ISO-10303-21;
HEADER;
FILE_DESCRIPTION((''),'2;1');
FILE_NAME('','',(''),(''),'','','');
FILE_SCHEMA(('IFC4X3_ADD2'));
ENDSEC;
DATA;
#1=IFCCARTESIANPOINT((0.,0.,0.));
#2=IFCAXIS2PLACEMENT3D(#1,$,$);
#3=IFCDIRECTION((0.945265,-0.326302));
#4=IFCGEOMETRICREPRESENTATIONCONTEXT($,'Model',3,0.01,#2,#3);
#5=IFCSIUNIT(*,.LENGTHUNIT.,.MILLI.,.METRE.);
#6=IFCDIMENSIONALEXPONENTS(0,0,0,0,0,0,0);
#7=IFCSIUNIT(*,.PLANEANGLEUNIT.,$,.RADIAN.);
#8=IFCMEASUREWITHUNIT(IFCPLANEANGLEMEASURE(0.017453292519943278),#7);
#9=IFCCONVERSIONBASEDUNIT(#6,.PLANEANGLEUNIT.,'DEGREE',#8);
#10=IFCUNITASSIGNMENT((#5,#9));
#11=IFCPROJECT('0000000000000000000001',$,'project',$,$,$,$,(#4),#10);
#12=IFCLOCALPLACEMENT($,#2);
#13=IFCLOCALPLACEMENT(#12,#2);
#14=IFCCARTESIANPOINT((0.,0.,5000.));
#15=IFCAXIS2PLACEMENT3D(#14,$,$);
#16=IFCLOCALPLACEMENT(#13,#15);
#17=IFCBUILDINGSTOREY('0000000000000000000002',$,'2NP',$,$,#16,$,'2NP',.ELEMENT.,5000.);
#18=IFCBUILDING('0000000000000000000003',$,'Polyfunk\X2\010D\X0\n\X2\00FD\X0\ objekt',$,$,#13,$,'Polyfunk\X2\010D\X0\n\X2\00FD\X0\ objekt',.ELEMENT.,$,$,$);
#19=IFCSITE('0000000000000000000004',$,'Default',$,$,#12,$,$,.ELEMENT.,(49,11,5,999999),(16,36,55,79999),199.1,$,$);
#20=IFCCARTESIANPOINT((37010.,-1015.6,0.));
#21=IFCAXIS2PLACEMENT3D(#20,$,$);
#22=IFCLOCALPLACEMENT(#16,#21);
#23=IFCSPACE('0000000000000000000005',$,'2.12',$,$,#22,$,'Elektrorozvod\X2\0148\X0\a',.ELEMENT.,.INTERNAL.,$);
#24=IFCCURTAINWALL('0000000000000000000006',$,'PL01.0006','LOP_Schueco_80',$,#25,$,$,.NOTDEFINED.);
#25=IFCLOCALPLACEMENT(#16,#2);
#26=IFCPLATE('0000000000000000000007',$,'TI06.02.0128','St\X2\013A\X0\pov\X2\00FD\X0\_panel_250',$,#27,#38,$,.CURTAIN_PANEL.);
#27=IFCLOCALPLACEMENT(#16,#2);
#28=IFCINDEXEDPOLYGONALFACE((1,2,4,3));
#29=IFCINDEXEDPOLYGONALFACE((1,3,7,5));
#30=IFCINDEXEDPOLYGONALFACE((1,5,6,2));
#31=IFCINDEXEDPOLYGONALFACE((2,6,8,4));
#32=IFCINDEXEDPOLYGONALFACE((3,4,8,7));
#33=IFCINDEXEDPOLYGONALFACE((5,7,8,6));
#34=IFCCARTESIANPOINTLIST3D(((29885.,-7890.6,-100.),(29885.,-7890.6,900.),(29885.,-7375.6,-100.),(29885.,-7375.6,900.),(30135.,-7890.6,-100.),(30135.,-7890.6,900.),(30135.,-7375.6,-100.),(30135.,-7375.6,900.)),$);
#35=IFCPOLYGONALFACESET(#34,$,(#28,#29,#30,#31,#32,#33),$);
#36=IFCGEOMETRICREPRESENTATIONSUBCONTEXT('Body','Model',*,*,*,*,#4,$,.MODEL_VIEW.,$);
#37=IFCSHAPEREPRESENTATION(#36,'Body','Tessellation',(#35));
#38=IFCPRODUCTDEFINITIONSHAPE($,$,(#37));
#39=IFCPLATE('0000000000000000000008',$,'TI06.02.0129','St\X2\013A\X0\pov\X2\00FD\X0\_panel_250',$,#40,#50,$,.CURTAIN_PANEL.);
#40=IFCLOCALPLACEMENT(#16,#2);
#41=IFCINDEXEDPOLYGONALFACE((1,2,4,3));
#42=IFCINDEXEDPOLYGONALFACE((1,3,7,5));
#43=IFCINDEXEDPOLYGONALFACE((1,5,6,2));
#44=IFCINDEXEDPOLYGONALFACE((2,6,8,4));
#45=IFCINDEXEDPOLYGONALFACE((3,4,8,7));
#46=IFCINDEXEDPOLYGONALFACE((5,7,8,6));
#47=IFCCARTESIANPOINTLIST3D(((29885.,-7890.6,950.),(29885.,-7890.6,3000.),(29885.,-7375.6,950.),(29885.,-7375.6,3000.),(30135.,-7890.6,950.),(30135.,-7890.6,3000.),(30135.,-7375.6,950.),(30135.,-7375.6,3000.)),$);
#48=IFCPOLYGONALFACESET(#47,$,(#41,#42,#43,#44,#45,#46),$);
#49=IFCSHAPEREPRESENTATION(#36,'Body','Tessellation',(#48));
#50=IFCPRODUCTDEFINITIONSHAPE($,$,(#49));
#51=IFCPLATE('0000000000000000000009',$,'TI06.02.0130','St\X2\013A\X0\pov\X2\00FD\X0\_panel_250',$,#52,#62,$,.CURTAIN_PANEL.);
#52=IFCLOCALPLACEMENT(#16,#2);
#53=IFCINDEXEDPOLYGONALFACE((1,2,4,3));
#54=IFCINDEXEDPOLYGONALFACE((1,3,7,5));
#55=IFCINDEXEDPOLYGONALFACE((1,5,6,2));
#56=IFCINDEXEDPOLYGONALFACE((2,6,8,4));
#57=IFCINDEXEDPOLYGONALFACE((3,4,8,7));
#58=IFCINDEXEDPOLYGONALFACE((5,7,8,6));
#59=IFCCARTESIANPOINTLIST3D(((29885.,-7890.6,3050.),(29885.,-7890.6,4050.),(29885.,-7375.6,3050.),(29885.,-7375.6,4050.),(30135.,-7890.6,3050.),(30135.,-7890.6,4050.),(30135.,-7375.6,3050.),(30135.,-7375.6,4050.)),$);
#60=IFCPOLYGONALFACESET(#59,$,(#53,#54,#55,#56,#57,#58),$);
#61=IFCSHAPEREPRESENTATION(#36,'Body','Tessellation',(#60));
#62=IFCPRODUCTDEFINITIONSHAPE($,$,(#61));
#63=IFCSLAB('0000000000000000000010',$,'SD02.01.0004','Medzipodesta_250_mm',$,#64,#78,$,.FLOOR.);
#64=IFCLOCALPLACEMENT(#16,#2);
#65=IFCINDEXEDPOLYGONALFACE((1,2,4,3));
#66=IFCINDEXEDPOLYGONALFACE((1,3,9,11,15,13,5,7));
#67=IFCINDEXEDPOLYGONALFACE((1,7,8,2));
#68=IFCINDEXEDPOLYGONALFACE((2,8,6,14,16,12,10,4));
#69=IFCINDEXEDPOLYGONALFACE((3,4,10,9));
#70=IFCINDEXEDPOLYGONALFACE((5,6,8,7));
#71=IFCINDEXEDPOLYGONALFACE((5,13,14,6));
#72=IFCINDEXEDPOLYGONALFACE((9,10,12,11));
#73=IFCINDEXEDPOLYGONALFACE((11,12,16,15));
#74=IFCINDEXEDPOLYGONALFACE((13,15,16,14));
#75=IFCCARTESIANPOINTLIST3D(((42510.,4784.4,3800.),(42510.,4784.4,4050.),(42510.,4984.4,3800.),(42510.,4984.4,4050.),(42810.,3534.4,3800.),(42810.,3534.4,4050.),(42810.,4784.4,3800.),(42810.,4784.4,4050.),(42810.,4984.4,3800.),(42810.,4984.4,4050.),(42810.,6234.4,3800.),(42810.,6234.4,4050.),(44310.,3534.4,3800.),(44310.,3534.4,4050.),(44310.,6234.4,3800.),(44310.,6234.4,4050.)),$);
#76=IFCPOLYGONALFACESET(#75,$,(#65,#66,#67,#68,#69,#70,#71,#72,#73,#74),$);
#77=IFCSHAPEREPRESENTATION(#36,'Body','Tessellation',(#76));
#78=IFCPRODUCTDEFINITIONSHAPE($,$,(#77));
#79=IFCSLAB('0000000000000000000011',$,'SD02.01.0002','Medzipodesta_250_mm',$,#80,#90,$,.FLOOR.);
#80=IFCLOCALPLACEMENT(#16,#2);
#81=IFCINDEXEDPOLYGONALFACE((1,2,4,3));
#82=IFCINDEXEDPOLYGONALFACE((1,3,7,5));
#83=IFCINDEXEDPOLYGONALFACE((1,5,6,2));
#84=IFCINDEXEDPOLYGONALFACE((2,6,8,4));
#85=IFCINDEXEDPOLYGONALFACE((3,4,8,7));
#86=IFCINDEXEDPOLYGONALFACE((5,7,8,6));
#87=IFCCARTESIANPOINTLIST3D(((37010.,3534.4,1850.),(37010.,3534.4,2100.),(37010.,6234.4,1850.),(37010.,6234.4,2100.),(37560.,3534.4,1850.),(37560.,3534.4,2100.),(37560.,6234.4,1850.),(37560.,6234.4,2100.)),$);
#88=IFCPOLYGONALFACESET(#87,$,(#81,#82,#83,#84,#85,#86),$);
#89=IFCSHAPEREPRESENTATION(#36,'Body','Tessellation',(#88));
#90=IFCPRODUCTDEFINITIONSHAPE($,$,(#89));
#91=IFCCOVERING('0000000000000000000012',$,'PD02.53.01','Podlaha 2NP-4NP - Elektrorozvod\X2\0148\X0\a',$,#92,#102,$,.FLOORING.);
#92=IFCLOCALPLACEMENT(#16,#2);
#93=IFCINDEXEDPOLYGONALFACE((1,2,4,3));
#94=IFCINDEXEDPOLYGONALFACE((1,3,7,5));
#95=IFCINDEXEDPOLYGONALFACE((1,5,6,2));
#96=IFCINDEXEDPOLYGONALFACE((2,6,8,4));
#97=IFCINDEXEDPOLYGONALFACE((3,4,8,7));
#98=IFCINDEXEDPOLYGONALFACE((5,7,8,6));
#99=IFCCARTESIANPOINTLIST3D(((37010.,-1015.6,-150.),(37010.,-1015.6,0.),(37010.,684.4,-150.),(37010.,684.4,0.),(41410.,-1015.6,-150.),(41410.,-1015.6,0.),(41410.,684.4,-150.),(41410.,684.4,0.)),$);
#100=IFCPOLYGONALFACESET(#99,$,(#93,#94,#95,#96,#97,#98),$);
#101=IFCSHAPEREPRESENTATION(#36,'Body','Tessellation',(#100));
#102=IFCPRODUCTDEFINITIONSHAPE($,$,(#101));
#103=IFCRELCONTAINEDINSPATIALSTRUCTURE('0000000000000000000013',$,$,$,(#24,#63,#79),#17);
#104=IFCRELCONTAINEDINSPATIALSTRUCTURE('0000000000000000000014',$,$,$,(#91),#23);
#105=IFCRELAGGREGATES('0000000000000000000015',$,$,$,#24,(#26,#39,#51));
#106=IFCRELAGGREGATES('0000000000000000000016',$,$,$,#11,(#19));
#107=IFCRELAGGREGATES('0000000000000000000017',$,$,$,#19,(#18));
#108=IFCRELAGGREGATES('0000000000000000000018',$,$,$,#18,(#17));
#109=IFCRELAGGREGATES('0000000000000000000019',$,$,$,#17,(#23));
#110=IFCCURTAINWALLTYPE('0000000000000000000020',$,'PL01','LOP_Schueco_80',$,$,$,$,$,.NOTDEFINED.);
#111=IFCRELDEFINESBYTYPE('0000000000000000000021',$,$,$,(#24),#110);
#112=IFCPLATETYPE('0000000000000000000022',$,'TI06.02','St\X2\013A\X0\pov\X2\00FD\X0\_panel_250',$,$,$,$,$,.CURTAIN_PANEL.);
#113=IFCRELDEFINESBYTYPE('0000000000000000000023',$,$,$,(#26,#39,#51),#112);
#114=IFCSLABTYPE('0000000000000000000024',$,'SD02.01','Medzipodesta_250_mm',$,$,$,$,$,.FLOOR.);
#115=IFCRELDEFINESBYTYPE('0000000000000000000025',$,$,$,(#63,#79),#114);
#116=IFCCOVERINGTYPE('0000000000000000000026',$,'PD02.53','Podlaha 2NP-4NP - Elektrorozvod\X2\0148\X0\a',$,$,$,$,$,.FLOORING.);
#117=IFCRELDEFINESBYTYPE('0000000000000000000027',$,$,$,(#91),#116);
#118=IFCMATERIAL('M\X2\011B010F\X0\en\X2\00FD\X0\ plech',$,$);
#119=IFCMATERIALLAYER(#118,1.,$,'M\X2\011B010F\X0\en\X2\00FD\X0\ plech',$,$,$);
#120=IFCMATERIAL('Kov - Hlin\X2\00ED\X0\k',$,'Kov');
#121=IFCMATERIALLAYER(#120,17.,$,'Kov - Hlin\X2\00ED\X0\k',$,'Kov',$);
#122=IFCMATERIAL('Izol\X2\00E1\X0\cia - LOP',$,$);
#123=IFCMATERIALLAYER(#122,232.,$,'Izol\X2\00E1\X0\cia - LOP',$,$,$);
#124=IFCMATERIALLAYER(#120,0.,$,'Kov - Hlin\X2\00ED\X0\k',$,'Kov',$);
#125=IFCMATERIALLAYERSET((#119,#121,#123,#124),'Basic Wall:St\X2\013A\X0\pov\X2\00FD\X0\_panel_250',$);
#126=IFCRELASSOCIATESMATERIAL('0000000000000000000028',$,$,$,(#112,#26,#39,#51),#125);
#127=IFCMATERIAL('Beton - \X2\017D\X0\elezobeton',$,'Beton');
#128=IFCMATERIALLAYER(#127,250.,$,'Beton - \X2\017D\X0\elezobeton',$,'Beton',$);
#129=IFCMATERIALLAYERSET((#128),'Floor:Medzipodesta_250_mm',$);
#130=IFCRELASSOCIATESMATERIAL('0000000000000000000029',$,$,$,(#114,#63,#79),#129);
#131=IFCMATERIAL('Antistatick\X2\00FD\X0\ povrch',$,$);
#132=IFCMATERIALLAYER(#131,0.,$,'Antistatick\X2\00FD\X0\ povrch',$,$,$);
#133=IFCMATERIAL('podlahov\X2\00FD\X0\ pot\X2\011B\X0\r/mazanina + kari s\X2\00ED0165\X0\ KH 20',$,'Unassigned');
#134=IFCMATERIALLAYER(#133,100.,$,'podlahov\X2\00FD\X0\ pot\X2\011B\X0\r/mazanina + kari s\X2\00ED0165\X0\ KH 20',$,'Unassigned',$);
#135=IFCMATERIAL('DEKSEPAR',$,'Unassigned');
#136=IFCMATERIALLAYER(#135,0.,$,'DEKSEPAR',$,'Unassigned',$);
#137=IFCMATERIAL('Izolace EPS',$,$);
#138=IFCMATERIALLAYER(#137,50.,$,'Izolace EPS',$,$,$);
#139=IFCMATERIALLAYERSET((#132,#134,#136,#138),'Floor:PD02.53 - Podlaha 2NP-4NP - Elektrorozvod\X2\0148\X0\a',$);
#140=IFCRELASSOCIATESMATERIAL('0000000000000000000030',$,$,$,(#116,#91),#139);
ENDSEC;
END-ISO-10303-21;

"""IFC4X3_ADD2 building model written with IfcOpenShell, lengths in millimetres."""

from ifc_helpers import new_model, entity, si_unit, converted_unit, direction, frame, frame_2d, origin, place, context, subcontext, project, spatial, polyline, rectangle, outline, extrude, material, layer, layer_set, layer_usage, type_object, element, aggregate, save


model = new_model("IFC4X3_ADD2")

# Units and contexts
model_context = context("Model", 3, precision=0.01, world=origin(), true_north=direction((0.945265, -0.326302)))
body_context = subcontext(model_context, "Body", "Model", "MODEL_VIEW")
ifc_project = project(units=[si_unit("LENGTHUNIT", "METRE", prefix="MILLI"), converted_unit("PLANEANGLEUNIT", "DEGREE", entity("IfcPlaneAngleMeasure", 0.017453292519943278), si_unit("PLANEANGLEUNIT", "RADIAN"), dimensions=[0, 0, 0, 0, 0, 0, 0])], contexts=[model_context])

# Site, building, storey
site_placement = place(None, origin())
site = spatial("IfcSite", under=ifc_project, at=site_placement, Name="Default", CompositionType="ELEMENT", RefLatitude=(49, 11, 5, 999999), RefLongitude=(16, 36, 55, 79999), RefElevation=199.1)
building_placement = place(site_placement, origin())
building = spatial("IfcBuilding", under=site, at=building_placement, Name="Polyfunkčný objekt", LongName="Polyfunkčný objekt", CompositionType="ELEMENT")
storey_placement = place(building_placement, frame((0.0, 0.0, 5000.0)))
storey = spatial("IfcBuildingStorey", under=building, at=storey_placement, Name="2NP", LongName="2NP", CompositionType="ELEMENT", Elevation=5000.0)

# Curtain wall
curtain_wall_type = type_object("IfcCurtainWallType", Name="PL01", Description="LOP_Schueco_80", PredefinedType="NOTDEFINED")
curtain_wall_1_placement = place(storey_placement, frame((0.0, 0.0, -5000.0)))
curtain_wall_1 = element("IfcCurtainWall", 1, at=curtain_wall_1_placement, inside=storey, type_object=curtain_wall_type, Name="PL01.0006", Description="LOP_Schueco_80", PredefinedType="NOTDEFINED")

# Shared definitions
ifc_material_1 = material(Name="Beton - Železobeton", Category="Beton")

# Shared definitions
ifc_material_2 = material(Name="Měďený plech")
ifc_layer_1 = layer(ifc_material_2, 1.0, Name="Měďený plech")
ifc_material_3 = material(Name="Kov - Hliník", Category="Kov")
ifc_layer_2 = layer(ifc_material_3, 17.0, Name="Kov - Hliník", Category="Kov")
ifc_material_4 = material(Name="Izolácia - LOP")
ifc_layer_3 = layer(ifc_material_4, 232.0, Name="Izolácia - LOP")
ifc_layer_4 = layer(ifc_material_3, 0.0, Name="Kov - Hliník", Category="Kov")
ifc_layer_set_1 = layer_set([ifc_layer_1, ifc_layer_2, ifc_layer_3, ifc_layer_4], Name="Basic Wall:Stĺpový_panel_250")
plate_type = type_object("IfcPlateType", Name="TI06.02", Description="Stĺpový_panel_250", PredefinedType="CURTAIN_PANEL", material=ifc_layer_set_1)

# Plates
ifc_layer_usage_1 = layer_usage(ifc_layer_set_1, "AXIS2", "POSITIVE", -125.0)
plate_1_placement = place(storey_placement, frame((30010.0, -7375.6, -100.0), z_axis=(0.0, 0.0, 1.0), x_axis=(0.0, -1.0, 0.0)))
plate_1 = element("IfcPlate", 2, at=plate_1_placement, type_object=plate_type, material=ifc_layer_usage_1, Name="TI06.02.0128", Description="Stĺpový_panel_250", PredefinedType="CURTAIN_PANEL", context=body_context, shape_type="SweptSolid", body=[
    extrude(rectangle(XDim=250.0, YDim=515.0, at=frame_2d((0.0, 0.0), x_axis=(1.0, 0.0))), frame((257.5, 0.0, 0.0), z_axis=(0.0, 0.0, 1.0), x_axis=(0.0, 1.0, 0.0)), (0.0, 0.0, 1.0), 1000.0),
])
ifc_layer_usage_2 = layer_usage(ifc_layer_set_1, "AXIS2", "POSITIVE", -125.0)
plate_2_placement = place(storey_placement, frame((30010.0, -7375.6, 950.0), z_axis=(0.0, 0.0, 1.0), x_axis=(0.0, -1.0, 0.0)))
plate_2 = element("IfcPlate", 3, at=plate_2_placement, type_object=plate_type, material=ifc_layer_usage_2, Name="TI06.02.0129", Description="Stĺpový_panel_250", PredefinedType="CURTAIN_PANEL", context=body_context, shape_type="SweptSolid", body=[
    extrude(rectangle(XDim=250.0, YDim=515.0, at=frame_2d((0.0, 0.0), x_axis=(1.0, 0.0))), frame((257.5, 0.0, 0.0), z_axis=(0.0, 0.0, 1.0), x_axis=(0.0, 1.0, 0.0)), (0.0, 0.0, 1.0), 2050.0),
])
ifc_layer_usage_3 = layer_usage(ifc_layer_set_1, "AXIS2", "POSITIVE", -125.0)
plate_3_placement = place(storey_placement, frame((30010.0, -7375.6, 3050.0), z_axis=(0.0, 0.0, 1.0), x_axis=(0.0, -1.0, 0.0)))
plate_3 = element("IfcPlate", 4, at=plate_3_placement, type_object=plate_type, material=ifc_layer_usage_3, Name="TI06.02.0130", Description="Stĺpový_panel_250", PredefinedType="CURTAIN_PANEL", context=body_context, shape_type="SweptSolid", body=[
    extrude(rectangle(XDim=250.0, YDim=515.0, at=frame_2d((0.0, 0.0), x_axis=(1.0, 0.0))), frame((257.5, 0.0, 0.0), z_axis=(0.0, 0.0, 1.0), x_axis=(0.0, 1.0, 0.0)), (0.0, 0.0, 1.0), 1000.0),
])
aggregate(curtain_wall_1, [plate_1, plate_2, plate_3])

# Slabs
ifc_layer_5 = layer(ifc_material_1, 250.0, Name="Beton - Železobeton", Category="Beton")
ifc_layer_set_2 = layer_set([ifc_layer_5], Name="Floor:Medzipodesta_250_mm")
ifc_layer_usage_4 = layer_usage(ifc_layer_set_2, "AXIS3", "POSITIVE", 0.0)
slab_type_1 = type_object("IfcSlabType", Name="SD02.01", Description="Medzipodesta_250_mm", PredefinedType="FLOOR", material=ifc_layer_set_2)
slab_1_placement = place(storey_placement, origin())
element("IfcSlab", 5, at=slab_1_placement, inside=storey, type_object=slab_type_1, material=ifc_layer_usage_4, Name="SD02.01.0004", Description="Medzipodesta_250_mm", PredefinedType="FLOOR", context=body_context, shape_type="SweptSolid", body=[
    extrude(outline(polyline([(-100.0, -600.0), (100.0, -600.0), (100.0, -300.0), (1350.0, -300.0), (1350.0, 1200.0), (-1350.0, 1200.0), (-1350.0, -300.0), (-100.0, -300.0), (-100.0, -600.0)])), frame((43110.0, 4884.4, 4050.0), z_axis=(0.0, 0.0, -1.0), x_axis=(0.0, 1.0, 0.0)), (0.0, 0.0, 1.0), 250.0),
])
ifc_layer_usage_5 = layer_usage(ifc_layer_set_2, "AXIS3", "POSITIVE", 0.0)
slab_2_placement = place(storey_placement, origin())
element("IfcSlab", 6, at=slab_2_placement, inside=storey, type_object=slab_type_1, material=ifc_layer_usage_5, Name="SD02.01.0002", Description="Medzipodesta_250_mm", PredefinedType="FLOOR", context=body_context, shape_type="SweptSolid", body=[
    extrude(rectangle(XDim=2700.0, YDim=550.0, at=frame_2d((0.0, 0.0), x_axis=(1.0, 0.0))), frame((37285.0, 4884.4, 2100.0), z_axis=(0.0, 0.0, -1.0), x_axis=(0.0, 1.0, 0.0)), (0.0, 0.0, 1.0), 250.0),
])

# Shared definitions
ifc_material_5 = material(Name="podlahový potěr/mazanina + kari síť KH 20", Category="Unassigned")
ifc_material_6 = material(Name="DEKSEPAR", Category="Unassigned")
ifc_material_7 = material(Name="Izolace EPS")

# Shared definitions
space_1_placement = place(storey_placement, frame((37010.0, -1015.6, 0.0)))
space_1 = spatial("IfcSpace", under=storey, at=space_1_placement, Name="2.12", LongName="Elektrorozvodňa", CompositionType="ELEMENT", PredefinedType="INTERNAL")

# Covering
ifc_material_8 = material(Name="Antistatický povrch")
ifc_layer_6 = layer(ifc_material_8, 0.0, Name="Antistatický povrch")
ifc_layer_7 = layer(ifc_material_5, 100.0, Name="podlahový potěr/mazanina + kari síť KH 20", Category="Unassigned")
ifc_layer_8 = layer(ifc_material_6, 0.0, Name="DEKSEPAR", Category="Unassigned")
ifc_layer_9 = layer(ifc_material_7, 50.0, Name="Izolace EPS")
ifc_layer_set_3 = layer_set([ifc_layer_6, ifc_layer_7, ifc_layer_8, ifc_layer_9], Name="Floor:PD02.53 - Podlaha 2NP-4NP - Elektrorozvodňa")
ifc_layer_usage_6 = layer_usage(ifc_layer_set_3, "AXIS3", "POSITIVE", 0.0)
covering_type_1 = type_object("IfcCoveringType", Name="PD02.53", Description="Podlaha 2NP-4NP - Elektrorozvodňa", PredefinedType="FLOORING", material=ifc_layer_set_3)
covering_1_placement = place(storey_placement, origin())
element("IfcCovering", 7, at=covering_1_placement, inside=space_1, type_object=covering_type_1, material=ifc_layer_usage_6, Name="PD02.53.01", Description="Podlaha 2NP-4NP - Elektrorozvodňa", PredefinedType="FLOORING", context=body_context, shape_type="SweptSolid", body=[
    extrude(rectangle(XDim=1700.0, YDim=4400.0, at=frame_2d((0.0, 0.0), x_axis=(1.0, 0.0))), frame((39210.0, -165.6, 0.0), z_axis=(0.0, 0.0, -1.0), x_axis=(0.0, 1.0, 0.0)), (0.0, 0.0, 1.0), 150.0),
])

save(model, "model.ifc")
